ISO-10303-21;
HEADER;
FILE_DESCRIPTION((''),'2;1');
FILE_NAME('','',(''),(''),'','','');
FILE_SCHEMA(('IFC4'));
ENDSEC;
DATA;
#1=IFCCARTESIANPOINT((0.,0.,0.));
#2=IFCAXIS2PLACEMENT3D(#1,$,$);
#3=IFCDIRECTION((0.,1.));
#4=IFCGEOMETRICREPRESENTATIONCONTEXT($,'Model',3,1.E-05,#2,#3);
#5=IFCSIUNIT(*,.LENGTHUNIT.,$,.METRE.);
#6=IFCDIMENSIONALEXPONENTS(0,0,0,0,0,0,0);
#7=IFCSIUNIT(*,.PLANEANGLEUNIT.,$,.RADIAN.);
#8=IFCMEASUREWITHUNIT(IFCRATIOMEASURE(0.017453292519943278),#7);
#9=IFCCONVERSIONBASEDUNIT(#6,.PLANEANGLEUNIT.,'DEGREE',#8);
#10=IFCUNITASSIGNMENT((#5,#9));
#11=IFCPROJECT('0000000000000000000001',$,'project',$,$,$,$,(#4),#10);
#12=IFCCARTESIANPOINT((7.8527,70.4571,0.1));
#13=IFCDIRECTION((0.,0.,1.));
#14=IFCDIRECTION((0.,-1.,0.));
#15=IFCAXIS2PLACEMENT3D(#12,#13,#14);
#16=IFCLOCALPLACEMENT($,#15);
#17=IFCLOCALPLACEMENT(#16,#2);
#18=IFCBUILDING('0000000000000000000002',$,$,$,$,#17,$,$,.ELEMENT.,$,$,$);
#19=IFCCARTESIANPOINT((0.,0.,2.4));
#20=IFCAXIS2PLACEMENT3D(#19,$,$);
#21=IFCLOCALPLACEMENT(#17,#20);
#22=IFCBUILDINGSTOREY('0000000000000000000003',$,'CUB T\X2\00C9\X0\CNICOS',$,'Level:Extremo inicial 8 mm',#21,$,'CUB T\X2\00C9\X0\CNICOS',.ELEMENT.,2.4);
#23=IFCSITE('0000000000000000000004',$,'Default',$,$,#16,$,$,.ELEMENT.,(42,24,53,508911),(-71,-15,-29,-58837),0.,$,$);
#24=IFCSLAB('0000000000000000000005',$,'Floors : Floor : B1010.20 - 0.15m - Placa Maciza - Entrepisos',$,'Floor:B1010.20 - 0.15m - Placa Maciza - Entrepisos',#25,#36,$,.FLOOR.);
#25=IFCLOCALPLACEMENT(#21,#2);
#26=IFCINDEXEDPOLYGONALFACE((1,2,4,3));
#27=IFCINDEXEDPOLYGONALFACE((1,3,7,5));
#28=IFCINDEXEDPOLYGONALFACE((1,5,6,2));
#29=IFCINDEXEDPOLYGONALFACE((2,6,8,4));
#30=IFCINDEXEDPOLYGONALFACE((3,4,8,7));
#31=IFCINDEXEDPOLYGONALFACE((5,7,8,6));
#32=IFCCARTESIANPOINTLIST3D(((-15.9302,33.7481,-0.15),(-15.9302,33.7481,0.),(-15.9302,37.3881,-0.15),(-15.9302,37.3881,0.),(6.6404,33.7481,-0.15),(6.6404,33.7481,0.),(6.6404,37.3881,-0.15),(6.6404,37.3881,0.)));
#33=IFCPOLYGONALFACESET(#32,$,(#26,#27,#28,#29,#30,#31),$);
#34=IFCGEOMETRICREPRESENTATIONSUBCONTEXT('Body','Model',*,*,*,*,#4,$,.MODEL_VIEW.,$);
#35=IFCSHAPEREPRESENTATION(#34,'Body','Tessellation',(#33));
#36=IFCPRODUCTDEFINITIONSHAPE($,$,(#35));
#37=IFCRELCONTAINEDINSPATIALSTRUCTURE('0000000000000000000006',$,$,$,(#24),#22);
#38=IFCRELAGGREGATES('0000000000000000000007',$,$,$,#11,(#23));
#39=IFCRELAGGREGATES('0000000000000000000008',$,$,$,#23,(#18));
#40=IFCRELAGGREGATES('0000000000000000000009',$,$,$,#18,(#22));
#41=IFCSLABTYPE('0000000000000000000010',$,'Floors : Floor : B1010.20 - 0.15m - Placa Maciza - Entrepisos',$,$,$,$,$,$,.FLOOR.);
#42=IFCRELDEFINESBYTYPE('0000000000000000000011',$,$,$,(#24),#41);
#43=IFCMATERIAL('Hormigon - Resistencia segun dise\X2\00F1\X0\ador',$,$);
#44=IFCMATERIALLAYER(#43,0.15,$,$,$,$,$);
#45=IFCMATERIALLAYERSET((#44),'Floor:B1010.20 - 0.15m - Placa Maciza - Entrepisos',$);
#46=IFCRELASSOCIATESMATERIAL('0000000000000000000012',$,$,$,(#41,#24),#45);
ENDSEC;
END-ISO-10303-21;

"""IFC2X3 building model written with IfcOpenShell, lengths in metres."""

from ifc_helpers import new_model, entity, si_unit, converted_unit, direction, frame, origin, origin_2d_with_axis, place, context, subcontext, project, spatial, rectangle, extrude, material, layer, layer_set, layer_usage, type_object, element, save


model = new_model("IFC2X3")

# Units and contexts
model_context = context("Model", 3, precision=1e-05, world=origin(), true_north=direction((0.0, 1.0)))
body_context = subcontext(model_context, "Body", "Model", "MODEL_VIEW")
ifc_project = project(units=[si_unit("LENGTHUNIT", "METRE"), converted_unit("PLANEANGLEUNIT", "DEGREE", entity("IfcRatioMeasure", 0.017453292519943278), si_unit("PLANEANGLEUNIT", "RADIAN"), dimensions=[0, 0, 0, 0, 0, 0, 0])], contexts=[model_context])

# Site, building, storey
site_placement = place(None, frame((7.8527, 70.4571, 0.1), z_axis=(0.0, 0.0, 1.0), x_axis=(0.0, -1.0, 0.0)))
site = spatial("IfcSite", under=ifc_project, at=site_placement, Name="Default", CompositionType="ELEMENT", RefLatitude=(42, 24, 53, 508911), RefLongitude=(-71, -15, -29, -58837), RefElevation=0.0)
building_placement = place(site_placement, origin())
building = spatial("IfcBuilding", under=site, at=building_placement, CompositionType="ELEMENT")
storey_placement = place(building_placement, frame((0.0, 0.0, 2.4)))
storey = spatial("IfcBuildingStorey", under=building, at=storey_placement, Name="CUB TÉCNICOS", ObjectType="Level:Extremo inicial 8 mm", LongName="CUB TÉCNICOS", CompositionType="ELEMENT", Elevation=2.4)

# Slab
ifc_material_1 = material(Name="Hormigon - Resistencia segun diseñador")
ifc_layer = layer(ifc_material_1, 0.15)
ifc_layer_set = layer_set([ifc_layer], Name="Floor:B1010.20 - 0.15m - Placa Maciza - Entrepisos")
ifc_layer_usage = layer_usage(ifc_layer_set, "AXIS3", "POSITIVE", 0.0)
slab_type = type_object("IfcSlabType", Name="Floors : Floor : B1010.20 - 0.15m - Placa Maciza - Entrepisos", PredefinedType="FLOOR", material=ifc_layer_set)
slab_placement = place(storey_placement, origin())
element("IfcSlab", 1, at=slab_placement, inside=storey, type_object=slab_type, material=ifc_layer_usage, Name="Floors : Floor : B1010.20 - 0.15m - Placa Maciza - Entrepisos", ObjectType="Floor:B1010.20 - 0.15m - Placa Maciza - Entrepisos", PredefinedType="FLOOR", context=body_context, shape_type="SweptSolid", body=[
    extrude(rectangle(XDim=3.6399, YDim=22.5706, at=origin_2d_with_axis()), frame((-4.6449, 35.5681, 0.0), z_axis=(0.0, 0.0, -1.0), x_axis=(0.0, 1.0, 0.0)), (0.0, 0.0, 1.0), 0.15),
])

save(model, "model.ifc")
